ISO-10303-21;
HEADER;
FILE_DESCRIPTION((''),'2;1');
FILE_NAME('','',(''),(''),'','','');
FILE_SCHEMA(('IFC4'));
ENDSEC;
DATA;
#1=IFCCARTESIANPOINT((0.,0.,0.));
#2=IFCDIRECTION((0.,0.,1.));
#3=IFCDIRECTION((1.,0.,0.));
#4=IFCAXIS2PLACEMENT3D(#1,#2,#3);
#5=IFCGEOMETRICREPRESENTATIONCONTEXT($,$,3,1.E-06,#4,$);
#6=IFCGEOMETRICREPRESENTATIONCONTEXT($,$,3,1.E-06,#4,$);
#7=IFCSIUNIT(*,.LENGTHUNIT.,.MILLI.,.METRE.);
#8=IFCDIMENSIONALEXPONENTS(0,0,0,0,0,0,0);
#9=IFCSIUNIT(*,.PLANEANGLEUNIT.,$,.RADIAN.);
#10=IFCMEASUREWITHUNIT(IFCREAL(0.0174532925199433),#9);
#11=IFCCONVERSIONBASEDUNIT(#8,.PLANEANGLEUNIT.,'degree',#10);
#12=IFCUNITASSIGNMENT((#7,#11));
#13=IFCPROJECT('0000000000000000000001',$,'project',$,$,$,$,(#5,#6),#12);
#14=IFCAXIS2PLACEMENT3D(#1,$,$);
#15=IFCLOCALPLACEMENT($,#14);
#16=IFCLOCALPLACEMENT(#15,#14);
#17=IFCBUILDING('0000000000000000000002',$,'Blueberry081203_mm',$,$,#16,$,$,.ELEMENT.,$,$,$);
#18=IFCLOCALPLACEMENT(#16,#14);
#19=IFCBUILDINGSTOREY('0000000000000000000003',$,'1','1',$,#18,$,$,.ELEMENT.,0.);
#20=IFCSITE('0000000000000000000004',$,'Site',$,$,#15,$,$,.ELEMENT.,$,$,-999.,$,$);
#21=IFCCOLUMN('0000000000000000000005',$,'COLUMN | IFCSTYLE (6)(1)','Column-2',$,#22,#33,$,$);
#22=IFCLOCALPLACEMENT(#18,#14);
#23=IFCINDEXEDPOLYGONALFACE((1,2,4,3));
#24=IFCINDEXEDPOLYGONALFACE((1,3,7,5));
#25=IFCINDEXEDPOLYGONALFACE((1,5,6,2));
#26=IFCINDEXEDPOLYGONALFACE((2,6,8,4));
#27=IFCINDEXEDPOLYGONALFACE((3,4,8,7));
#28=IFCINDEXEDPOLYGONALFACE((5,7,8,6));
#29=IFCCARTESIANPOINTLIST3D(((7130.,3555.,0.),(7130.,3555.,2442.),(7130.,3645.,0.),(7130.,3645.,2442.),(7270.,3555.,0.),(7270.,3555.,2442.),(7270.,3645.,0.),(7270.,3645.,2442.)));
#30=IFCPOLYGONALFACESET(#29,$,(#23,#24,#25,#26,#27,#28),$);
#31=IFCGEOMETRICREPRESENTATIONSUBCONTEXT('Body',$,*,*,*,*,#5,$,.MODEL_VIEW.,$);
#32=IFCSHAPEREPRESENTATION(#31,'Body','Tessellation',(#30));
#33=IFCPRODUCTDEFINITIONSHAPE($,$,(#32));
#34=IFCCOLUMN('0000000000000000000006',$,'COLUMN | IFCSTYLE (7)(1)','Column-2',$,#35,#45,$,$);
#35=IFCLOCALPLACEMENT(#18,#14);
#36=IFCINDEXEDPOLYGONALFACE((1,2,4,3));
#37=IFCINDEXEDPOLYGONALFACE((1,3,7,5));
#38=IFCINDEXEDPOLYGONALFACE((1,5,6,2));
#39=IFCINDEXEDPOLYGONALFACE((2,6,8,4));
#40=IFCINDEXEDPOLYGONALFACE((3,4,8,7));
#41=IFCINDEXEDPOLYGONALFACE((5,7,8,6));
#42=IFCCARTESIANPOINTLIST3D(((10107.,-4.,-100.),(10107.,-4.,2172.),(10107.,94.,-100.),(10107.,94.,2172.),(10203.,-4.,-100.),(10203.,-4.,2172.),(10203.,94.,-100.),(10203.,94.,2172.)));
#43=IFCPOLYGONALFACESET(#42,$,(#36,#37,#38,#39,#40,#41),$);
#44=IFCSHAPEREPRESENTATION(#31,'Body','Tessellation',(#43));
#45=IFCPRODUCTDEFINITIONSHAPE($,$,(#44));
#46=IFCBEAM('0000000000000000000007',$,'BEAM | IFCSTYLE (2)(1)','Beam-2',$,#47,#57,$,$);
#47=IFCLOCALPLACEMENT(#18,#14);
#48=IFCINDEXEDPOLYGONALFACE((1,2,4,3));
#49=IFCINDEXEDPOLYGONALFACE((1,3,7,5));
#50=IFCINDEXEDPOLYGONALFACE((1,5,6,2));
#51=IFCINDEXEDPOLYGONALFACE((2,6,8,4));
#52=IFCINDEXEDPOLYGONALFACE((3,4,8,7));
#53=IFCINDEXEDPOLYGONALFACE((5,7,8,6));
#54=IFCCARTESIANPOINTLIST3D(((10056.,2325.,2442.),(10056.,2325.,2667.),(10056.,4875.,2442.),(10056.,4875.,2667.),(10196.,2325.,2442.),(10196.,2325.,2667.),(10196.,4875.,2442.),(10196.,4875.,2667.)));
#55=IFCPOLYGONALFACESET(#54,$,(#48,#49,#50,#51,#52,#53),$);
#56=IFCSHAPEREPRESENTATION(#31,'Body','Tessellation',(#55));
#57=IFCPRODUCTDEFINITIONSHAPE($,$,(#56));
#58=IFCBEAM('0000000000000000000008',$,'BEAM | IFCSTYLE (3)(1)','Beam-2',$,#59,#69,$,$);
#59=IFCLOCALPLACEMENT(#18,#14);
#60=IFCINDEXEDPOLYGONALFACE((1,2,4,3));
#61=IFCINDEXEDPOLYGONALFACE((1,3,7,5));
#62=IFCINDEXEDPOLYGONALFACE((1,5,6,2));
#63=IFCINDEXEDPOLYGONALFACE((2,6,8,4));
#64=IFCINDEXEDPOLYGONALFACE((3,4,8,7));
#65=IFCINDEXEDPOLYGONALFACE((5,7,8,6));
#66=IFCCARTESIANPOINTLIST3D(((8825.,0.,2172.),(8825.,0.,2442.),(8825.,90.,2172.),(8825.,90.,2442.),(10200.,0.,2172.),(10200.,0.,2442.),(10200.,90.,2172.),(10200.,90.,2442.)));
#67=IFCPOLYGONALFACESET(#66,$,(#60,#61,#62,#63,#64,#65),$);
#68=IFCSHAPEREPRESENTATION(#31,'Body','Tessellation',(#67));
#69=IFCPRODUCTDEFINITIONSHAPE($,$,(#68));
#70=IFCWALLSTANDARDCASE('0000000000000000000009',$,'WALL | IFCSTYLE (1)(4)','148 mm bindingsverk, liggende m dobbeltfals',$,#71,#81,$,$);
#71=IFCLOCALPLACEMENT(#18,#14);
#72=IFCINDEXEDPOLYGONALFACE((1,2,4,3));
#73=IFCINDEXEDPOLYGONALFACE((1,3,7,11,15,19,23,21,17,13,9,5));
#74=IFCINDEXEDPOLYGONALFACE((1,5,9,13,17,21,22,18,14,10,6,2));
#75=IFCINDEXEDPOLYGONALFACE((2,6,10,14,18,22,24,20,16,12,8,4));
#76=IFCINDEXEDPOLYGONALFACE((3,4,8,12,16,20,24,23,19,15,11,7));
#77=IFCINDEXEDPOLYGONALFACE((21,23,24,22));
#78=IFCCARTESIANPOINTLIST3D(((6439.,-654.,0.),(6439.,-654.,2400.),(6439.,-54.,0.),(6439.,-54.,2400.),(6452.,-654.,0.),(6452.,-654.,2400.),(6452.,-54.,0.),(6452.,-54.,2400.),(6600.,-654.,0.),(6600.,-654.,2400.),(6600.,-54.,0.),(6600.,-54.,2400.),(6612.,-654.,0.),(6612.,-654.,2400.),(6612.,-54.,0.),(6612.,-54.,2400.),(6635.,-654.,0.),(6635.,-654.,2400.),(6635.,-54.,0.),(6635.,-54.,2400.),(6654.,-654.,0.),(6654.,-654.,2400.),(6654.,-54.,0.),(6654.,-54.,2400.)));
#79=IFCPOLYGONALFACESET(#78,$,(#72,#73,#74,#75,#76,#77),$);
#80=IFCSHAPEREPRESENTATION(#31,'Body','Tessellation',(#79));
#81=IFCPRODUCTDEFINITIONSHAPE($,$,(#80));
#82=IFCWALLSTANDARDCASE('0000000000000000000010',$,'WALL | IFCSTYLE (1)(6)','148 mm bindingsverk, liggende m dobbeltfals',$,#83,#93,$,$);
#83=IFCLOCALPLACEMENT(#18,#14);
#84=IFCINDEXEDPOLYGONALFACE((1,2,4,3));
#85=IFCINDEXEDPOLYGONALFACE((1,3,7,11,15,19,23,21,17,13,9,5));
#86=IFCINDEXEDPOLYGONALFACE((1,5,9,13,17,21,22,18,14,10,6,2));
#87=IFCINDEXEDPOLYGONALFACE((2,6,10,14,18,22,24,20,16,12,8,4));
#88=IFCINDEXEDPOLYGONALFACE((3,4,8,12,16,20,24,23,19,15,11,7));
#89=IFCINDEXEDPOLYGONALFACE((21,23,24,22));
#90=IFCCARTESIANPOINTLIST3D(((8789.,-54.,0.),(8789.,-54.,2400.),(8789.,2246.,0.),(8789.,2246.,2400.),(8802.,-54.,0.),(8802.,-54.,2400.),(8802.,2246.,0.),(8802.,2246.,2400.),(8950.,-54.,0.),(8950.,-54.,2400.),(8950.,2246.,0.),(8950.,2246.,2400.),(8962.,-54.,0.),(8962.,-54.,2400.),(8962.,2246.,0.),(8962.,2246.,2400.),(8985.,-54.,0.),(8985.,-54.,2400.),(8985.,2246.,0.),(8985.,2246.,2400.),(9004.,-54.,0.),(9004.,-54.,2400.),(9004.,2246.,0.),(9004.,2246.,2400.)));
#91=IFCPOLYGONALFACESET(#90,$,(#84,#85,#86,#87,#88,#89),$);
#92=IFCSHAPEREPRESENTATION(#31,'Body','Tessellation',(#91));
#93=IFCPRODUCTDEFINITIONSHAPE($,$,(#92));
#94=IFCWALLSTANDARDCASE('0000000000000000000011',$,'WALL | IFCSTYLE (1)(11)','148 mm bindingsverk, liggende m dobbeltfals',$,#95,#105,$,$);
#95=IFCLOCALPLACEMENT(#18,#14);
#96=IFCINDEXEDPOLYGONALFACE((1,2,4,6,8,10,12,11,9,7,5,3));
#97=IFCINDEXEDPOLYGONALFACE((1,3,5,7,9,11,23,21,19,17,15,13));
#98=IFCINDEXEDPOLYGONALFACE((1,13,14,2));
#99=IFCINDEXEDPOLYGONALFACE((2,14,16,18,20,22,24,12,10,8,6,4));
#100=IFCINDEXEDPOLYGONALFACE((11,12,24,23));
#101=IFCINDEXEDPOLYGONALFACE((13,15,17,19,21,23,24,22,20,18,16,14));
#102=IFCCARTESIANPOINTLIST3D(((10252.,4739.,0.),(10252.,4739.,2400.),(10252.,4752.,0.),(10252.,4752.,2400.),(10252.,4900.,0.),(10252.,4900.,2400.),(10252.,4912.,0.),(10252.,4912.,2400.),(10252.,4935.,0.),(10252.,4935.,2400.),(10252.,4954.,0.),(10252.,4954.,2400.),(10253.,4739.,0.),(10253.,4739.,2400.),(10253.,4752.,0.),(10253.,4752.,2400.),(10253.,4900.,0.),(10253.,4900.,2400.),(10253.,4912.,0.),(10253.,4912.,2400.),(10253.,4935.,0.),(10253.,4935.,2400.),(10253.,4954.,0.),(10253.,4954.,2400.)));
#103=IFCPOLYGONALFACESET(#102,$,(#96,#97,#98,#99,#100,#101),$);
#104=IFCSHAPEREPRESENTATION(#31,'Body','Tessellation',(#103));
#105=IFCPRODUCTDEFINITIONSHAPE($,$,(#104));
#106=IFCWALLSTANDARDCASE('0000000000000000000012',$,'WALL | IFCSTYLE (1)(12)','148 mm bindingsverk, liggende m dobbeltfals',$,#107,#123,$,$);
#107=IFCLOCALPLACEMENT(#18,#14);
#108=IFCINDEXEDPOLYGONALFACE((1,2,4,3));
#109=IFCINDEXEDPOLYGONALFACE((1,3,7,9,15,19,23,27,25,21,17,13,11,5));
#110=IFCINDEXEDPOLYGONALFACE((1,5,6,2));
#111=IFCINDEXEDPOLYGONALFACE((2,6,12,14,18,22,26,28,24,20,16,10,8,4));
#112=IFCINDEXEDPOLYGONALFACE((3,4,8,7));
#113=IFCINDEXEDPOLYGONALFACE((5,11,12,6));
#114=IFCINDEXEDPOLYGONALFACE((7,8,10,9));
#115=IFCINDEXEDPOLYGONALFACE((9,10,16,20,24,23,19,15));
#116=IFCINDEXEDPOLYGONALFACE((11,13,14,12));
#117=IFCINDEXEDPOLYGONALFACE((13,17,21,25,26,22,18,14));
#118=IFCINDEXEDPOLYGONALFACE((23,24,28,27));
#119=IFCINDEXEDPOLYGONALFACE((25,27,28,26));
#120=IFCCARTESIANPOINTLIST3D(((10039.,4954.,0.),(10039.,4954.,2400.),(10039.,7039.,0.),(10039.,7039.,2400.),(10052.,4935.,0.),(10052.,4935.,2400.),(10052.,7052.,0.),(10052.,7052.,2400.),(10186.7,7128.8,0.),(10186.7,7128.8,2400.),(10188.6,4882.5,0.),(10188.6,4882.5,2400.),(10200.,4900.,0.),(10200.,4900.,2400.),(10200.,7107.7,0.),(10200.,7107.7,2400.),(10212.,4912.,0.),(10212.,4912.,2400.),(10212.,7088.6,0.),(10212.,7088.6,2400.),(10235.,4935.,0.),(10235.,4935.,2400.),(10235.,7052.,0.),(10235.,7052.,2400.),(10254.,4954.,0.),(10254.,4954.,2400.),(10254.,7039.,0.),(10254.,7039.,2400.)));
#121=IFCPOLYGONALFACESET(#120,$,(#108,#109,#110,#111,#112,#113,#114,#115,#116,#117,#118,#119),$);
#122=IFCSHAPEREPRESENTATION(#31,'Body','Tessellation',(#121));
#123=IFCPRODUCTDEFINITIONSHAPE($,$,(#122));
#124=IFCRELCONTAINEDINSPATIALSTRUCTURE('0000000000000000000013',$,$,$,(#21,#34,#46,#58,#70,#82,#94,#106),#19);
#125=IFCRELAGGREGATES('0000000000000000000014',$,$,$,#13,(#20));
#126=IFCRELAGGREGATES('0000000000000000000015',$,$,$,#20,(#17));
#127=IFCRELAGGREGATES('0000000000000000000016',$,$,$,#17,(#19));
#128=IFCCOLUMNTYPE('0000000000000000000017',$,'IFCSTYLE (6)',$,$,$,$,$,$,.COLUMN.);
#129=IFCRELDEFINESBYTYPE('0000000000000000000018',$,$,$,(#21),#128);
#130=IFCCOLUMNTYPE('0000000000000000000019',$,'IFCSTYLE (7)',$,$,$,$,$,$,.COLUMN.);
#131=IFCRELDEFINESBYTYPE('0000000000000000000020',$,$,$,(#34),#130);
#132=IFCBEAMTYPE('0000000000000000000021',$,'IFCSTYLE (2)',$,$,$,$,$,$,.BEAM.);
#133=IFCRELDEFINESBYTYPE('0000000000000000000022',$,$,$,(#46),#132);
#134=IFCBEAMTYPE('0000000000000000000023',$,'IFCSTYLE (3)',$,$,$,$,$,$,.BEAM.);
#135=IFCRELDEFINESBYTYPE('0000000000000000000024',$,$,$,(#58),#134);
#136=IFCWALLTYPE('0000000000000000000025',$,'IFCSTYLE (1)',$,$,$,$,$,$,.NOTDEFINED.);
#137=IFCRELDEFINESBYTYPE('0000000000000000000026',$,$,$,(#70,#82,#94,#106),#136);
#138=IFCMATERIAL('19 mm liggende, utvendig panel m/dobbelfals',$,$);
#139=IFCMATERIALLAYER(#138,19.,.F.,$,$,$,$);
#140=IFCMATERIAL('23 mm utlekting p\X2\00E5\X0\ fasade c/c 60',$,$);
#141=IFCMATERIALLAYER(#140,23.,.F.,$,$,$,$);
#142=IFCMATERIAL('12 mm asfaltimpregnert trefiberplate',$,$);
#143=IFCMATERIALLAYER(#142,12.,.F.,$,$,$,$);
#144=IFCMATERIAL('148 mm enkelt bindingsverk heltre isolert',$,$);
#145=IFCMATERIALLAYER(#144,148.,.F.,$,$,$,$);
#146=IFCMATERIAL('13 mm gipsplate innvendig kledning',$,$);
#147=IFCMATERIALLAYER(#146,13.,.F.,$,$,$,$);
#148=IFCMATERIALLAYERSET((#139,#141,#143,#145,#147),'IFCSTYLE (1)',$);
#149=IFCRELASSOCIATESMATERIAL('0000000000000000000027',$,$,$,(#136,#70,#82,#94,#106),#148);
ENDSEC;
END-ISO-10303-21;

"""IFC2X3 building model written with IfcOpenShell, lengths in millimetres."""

from ifc_helpers import new_model, entity, si_unit, converted_unit, frame, frame_2d, origin, origin_with_axes, place, context, subcontext, project, spatial, polyline, segment, composite_curve, rectangle, outline, extrude, source, transform, mapped, material, layer, layer_set, layer_usage, type_object, element, save


model = new_model("IFC2X3")

# Units and contexts
context_of_model_1 = context(None, 3, precision=1e-06, world=origin_with_axes())
context_of_model_2 = context(None, 3, precision=1e-06, world=origin_with_axes())
body_context = subcontext(context_of_model_1, "Body", None, "MODEL_VIEW")
ifc_project = project(units=[si_unit("LENGTHUNIT", "METRE", prefix="MILLI"), converted_unit("PLANEANGLEUNIT", "degree", entity("IfcReal", 0.0174532925199433), si_unit("PLANEANGLEUNIT", "RADIAN"), dimensions=[0, 0, 0, 0, 0, 0, 0])], contexts=[context_of_model_1, context_of_model_2])

# Site, building, storey
site_placement = place(None, origin())
site = spatial("IfcSite", under=ifc_project, at=site_placement, Name="Site", CompositionType="ELEMENT", RefElevation=-999.0)
building_placement = place(site_placement, origin())
building = spatial("IfcBuilding", under=site, at=building_placement, Name="Blueberry081203_mm", CompositionType="ELEMENT")
storey_placement = place(building_placement, origin())
storey = spatial("IfcBuildingStorey", under=building, at=storey_placement, Name="1", Description="1", CompositionType="ELEMENT", Elevation=0.0)

# Columns
column_type_1 = type_object("IfcColumnType", Name="IFCSTYLE (6)", PredefinedType="COLUMN")
shared_shape_1 = source(origin(), body_context, "Body", "SweptSolid", [
    extrude(rectangle(XDim=140.0, YDim=90.0, at=frame_2d((70.0, 45.0), x_axis=(1.0, 0.0))), frame((0.0, 0.0, 0.0), z_axis=(1.0, 0.0, 0.0), x_axis=(0.0, 1.0, 0.0)), (0.0, 0.0, 1.0), 1.0),
])
column_1_placement = place(storey_placement, frame((7130.0, 3555.0, 0.0), z_axis=(0.0, 1.0, 0.0), x_axis=(0.0, 0.0, 1.0)))
element("IfcColumn", 1, at=column_1_placement, inside=storey, type_object=column_type_1, Name="COLUMN | IFCSTYLE (6)(1)", Description="Column-2", context=body_context, shape_type="MappedRepresentation", held_by="IfcProductRepresentation", body=[
    mapped(shared_shape_1, transform((0.0, 0.0, 0.0), x_axis=(1.0, 0.0, 0.0), y_axis=(0.0, 1.0, 0.0), z_axis=(0.0, 0.0, 1.0), scale=2441.999912, scale2=1.0, scale3=1.0, uniform=False)),
])
column_type_2 = type_object("IfcColumnType", Name="IFCSTYLE (7)", PredefinedType="COLUMN")
shared_shape_2 = source(origin(), body_context, "Body", "SweptSolid", [
    extrude(rectangle(XDim=96.0, YDim=98.0, at=frame_2d((48.0, 49.0), x_axis=(1.0, 0.0))), frame((0.0, 0.0, 0.0), z_axis=(1.0, 0.0, 0.0), x_axis=(0.0, 1.0, 0.0)), (0.0, 0.0, 1.0), 1.0),
])
column_2_placement = place(storey_placement, frame((10107.0, -4.0, -100.0), z_axis=(0.0, 1.0, 0.0), x_axis=(0.0, 0.0, 1.0)))
element("IfcColumn", 2, at=column_2_placement, inside=storey, type_object=column_type_2, Name="COLUMN | IFCSTYLE (7)(1)", Description="Column-2", context=body_context, shape_type="MappedRepresentation", held_by="IfcProductRepresentation", body=[
    mapped(shared_shape_2, transform((0.0, 0.0, 0.0), x_axis=(1.0, 0.0, 0.0), y_axis=(0.0, 1.0, 0.0), z_axis=(0.0, 0.0, 1.0), scale=2272.000074, scale2=1.0, scale3=1.0, uniform=False)),
])

# Beams
beam_type_1 = type_object("IfcBeamType", Name="IFCSTYLE (2)", PredefinedType="BEAM")
shared_shape_3 = source(origin(), body_context, "Body", "SweptSolid", [
    extrude(rectangle(XDim=140.0, YDim=225.0, at=frame_2d((70.0, 112.5), x_axis=(1.0, 0.0))), frame((0.0, 0.0, 0.0), z_axis=(1.0, 0.0, 0.0), x_axis=(0.0, 1.0, 0.0)), (0.0, 0.0, 1.0), 1.0),
])
beam_1_placement = place(storey_placement, frame((10056.0, 4875.0, 2442.0), z_axis=(0.0, 0.0, 1.0), x_axis=(0.0, -1.0, 0.0)))
element("IfcBeam", 3, at=beam_1_placement, inside=storey, type_object=beam_type_1, Name="BEAM | IFCSTYLE (2)(1)", Description="Beam-2", context=body_context, shape_type="MappedRepresentation", held_by="IfcProductRepresentation", body=[
    mapped(shared_shape_3, transform((0.0, 0.0, 0.0), x_axis=(1.0, 0.0, 0.0), y_axis=(0.0, 1.0, 0.0), z_axis=(0.0, 0.0, 1.0), scale=2549.999952, scale2=1.0, scale3=1.0, uniform=False)),
])
beam_type_2 = type_object("IfcBeamType", Name="IFCSTYLE (3)", PredefinedType="BEAM")
shared_shape_4 = source(origin(), body_context, "Body", "SweptSolid", [
    extrude(rectangle(XDim=90.0, YDim=270.0, at=frame_2d((45.0, 135.0), x_axis=(1.0, 0.0))), frame((0.0, 0.0, 0.0), z_axis=(1.0, 0.0, 0.0), x_axis=(0.0, 1.0, 0.0)), (0.0, 0.0, 1.0), 1.0),
])
beam_2_placement = place(storey_placement, frame((8825.0, 0.0, 2172.0)))
element("IfcBeam", 4, at=beam_2_placement, inside=storey, type_object=beam_type_2, Name="BEAM | IFCSTYLE (3)(1)", Description="Beam-2", context=body_context, shape_type="MappedRepresentation", held_by="IfcProductRepresentation", body=[
    mapped(shared_shape_4, transform((0.0, 0.0, 0.0), x_axis=(1.0, 0.0, 0.0), y_axis=(0.0, 1.0, 0.0), z_axis=(0.0, 0.0, 1.0), scale=1374.999046, scale2=1.0, scale3=1.0, uniform=False)),
])

# Wall
ifc_material_1 = material(Name="19 mm liggende, utvendig panel m/dobbelfals")
ifc_layer_1 = layer(ifc_material_1, 19.0, ventilated=False)
ifc_material_2 = material(Name="23 mm utlekting på fasade c/c 60")
ifc_layer_2 = layer(ifc_material_2, 23.0, ventilated=False)
ifc_material_3 = material(Name="12 mm asfaltimpregnert trefiberplate")
ifc_layer_3 = layer(ifc_material_3, 12.0, ventilated=False)
ifc_material_4 = material(Name="148 mm enkelt bindingsverk heltre isolert")
ifc_layer_4 = layer(ifc_material_4, 148.0, ventilated=False)
ifc_material_5 = material(Name="13 mm gipsplate innvendig kledning")
ifc_layer_5 = layer(ifc_material_5, 13.0, ventilated=False)
ifc_layer_set_1 = layer_set([ifc_layer_1, ifc_layer_2, ifc_layer_3, ifc_layer_4, ifc_layer_5], Name="IFCSTYLE (1)")
ifc_layer_usage_1 = layer_usage(ifc_layer_set_1, "AXIS2", "POSITIVE", 0.0)
wall_type_1 = type_object("IfcWallType", Name="IFCSTYLE (1)", PredefinedType="NOTDEFINED", material=ifc_layer_set_1)
wall_1_placement = place(storey_placement, frame((6654.0, -654.0, 0.0), z_axis=(0.0, 0.0, 1.0), x_axis=(0.0, 1.0, 0.0)))
element("IfcWallStandardCase", 5, at=wall_1_placement, inside=storey, type_object=wall_type_1, material=ifc_layer_usage_1, Name="WALL | IFCSTYLE (1)(4)", Description="148 mm bindingsverk, liggende m dobbeltfals", context=body_context, shape_type="SweptSolid", held_by="IfcProductRepresentation", body=[
    extrude(outline(composite_curve([segment(polyline([(0.0, 19.0), (0.0, 0.0)]), True, "CONTINUOUS"), segment(polyline([(0.0, 0.0), (600.0, 0.0)]), True, "CONTINUOUS"), segment(polyline([(600.0, 0.0), (600.0, 19.0)]), True, "CONTINUOUS"), segment(polyline([(600.0, 19.0), (600.0, 42.0)]), True, "CONTINUOUS"), segment(polyline([(600.0, 42.0), (600.0, 54.0)]), True, "CONTINUOUS"), segment(polyline([(600.0, 54.0), (600.0, 202.0)]), True, "CONTINUOUS"), segment(polyline([(600.0, 202.0), (600.0, 215.0)]), True, "CONTINUOUS"), segment(polyline([(600.0, 215.0), (0.0, 215.0)]), True, "CONTINUOUS"), segment(polyline([(0.0, 215.0), (0.0, 202.0)]), True, "CONTINUOUS"), segment(polyline([(0.0, 202.0), (0.0, 54.0)]), True, "CONTINUOUS"), segment(polyline([(0.0, 54.0), (0.0, 42.0)]), True, "CONTINUOUS"), segment(polyline([(0.0, 42.0), (0.0, 19.0)]), True, "CONTINUOUS")], self_intersect=False)), origin(), (0.0, 0.0, 1.0), 2400.0),
])

# Wall
ifc_layer_usage_2 = layer_usage(ifc_layer_set_1, "AXIS2", "POSITIVE", 0.0)
wall_2_placement = place(storey_placement, frame((9004.0, -54.0, 0.0), z_axis=(0.0, 0.0, 1.0), x_axis=(0.0, 1.0, 0.0)))
element("IfcWallStandardCase", 6, at=wall_2_placement, inside=storey, type_object=wall_type_1, material=ifc_layer_usage_2, Name="WALL | IFCSTYLE (1)(6)", Description="148 mm bindingsverk, liggende m dobbeltfals", context=body_context, shape_type="SweptSolid", held_by="IfcProductRepresentation", body=[
    extrude(outline(composite_curve([segment(polyline([(0.0, 19.0), (0.0, 0.0)]), True, "CONTINUOUS"), segment(polyline([(0.0, 0.0), (2300.0, 0.0)]), True, "CONTINUOUS"), segment(polyline([(2300.0, 0.0), (2300.0, 19.0)]), True, "CONTINUOUS"), segment(polyline([(2300.0, 19.0), (2300.0, 42.0)]), True, "CONTINUOUS"), segment(polyline([(2300.0, 42.0), (2300.0, 54.0)]), True, "CONTINUOUS"), segment(polyline([(2300.0, 54.0), (2300.0, 202.0)]), True, "CONTINUOUS"), segment(polyline([(2300.0, 202.0), (2300.0, 215.0)]), True, "CONTINUOUS"), segment(polyline([(2300.0, 215.0), (0.0, 215.0)]), True, "CONTINUOUS"), segment(polyline([(0.0, 215.0), (0.0, 202.0)]), True, "CONTINUOUS"), segment(polyline([(0.0, 202.0), (0.0, 54.0)]), True, "CONTINUOUS"), segment(polyline([(0.0, 54.0), (0.0, 42.0)]), True, "CONTINUOUS"), segment(polyline([(0.0, 42.0), (0.0, 19.0)]), True, "CONTINUOUS")], self_intersect=False)), origin(), (0.0, 0.0, 1.0), 2400.0),
])

# Walls
ifc_layer_usage_3 = layer_usage(ifc_layer_set_1, "AXIS2", "POSITIVE", 0.0)
wall_3_placement = place(storey_placement, frame((10253.0, 4954.0, 0.0), z_axis=(0.0, 0.0, 1.0), x_axis=(-1.0, 0.0, 0.0)))
element("IfcWallStandardCase", 7, at=wall_3_placement, inside=storey, type_object=wall_type_1, material=ifc_layer_usage_3, Name="WALL | IFCSTYLE (1)(11)", Description="148 mm bindingsverk, liggende m dobbeltfals", context=body_context, shape_type="SweptSolid", held_by="IfcProductRepresentation", body=[
    extrude(outline(composite_curve([segment(polyline([(0.0, 19.0), (0.0, 0.0)]), True, "CONTINUOUS"), segment(polyline([(0.0, 0.0), (1.0, 0.0)]), True, "CONTINUOUS"), segment(polyline([(1.0, 0.0), (1.0, 19.0)]), True, "CONTINUOUS"), segment(polyline([(1.0, 19.0), (1.0, 42.0)]), True, "CONTINUOUS"), segment(polyline([(1.0, 42.0), (1.0, 54.0)]), True, "CONTINUOUS"), segment(polyline([(1.0, 54.0), (1.0, 202.0)]), True, "CONTINUOUS"), segment(polyline([(1.0, 202.0), (1.0, 215.0)]), True, "CONTINUOUS"), segment(polyline([(1.0, 215.0), (0.0, 215.0)]), True, "CONTINUOUS"), segment(polyline([(0.0, 215.0), (0.0, 202.0)]), True, "CONTINUOUS"), segment(polyline([(0.0, 202.0), (0.0, 54.0)]), True, "CONTINUOUS"), segment(polyline([(0.0, 54.0), (0.0, 42.0)]), True, "CONTINUOUS"), segment(polyline([(0.0, 42.0), (0.0, 19.0)]), True, "CONTINUOUS")], self_intersect=False)), origin(), (0.0, 0.0, 1.0), 2400.0),
])
ifc_layer_usage_4 = layer_usage(ifc_layer_set_1, "AXIS2", "POSITIVE", 0.0)
wall_4_placement = place(storey_placement, frame((10254.0, 4954.0, 0.0), z_axis=(0.0, 0.0, 1.0), x_axis=(0.0, 1.0, 0.0)))
element("IfcWallStandardCase", 8, at=wall_4_placement, inside=storey, type_object=wall_type_1, material=ifc_layer_usage_4, Name="WALL | IFCSTYLE (1)(12)", Description="148 mm bindingsverk, liggende m dobbeltfals", context=body_context, shape_type="SweptSolid", held_by="IfcProductRepresentation", body=[
    extrude(outline(composite_curve([segment(polyline([(-19.0, 19.0), (0.0, 0.0)]), True, "CONTINUOUS"), segment(polyline([(0.0, 0.0), (2085.0, 0.0)]), True, "CONTINUOUS"), segment(polyline([(2085.0, 0.0), (2098.0, 19.0)]), True, "CONTINUOUS"), segment(polyline([(2098.0, 19.0), (2134.6, 42.0)]), True, "CONTINUOUS"), segment(polyline([(2134.6, 42.0), (2153.7, 54.0)]), True, "CONTINUOUS"), segment(polyline([(2153.7, 54.0), (2174.8, 67.2)]), True, "CONTINUOUS"), segment(polyline([(2174.8, 67.2), (2098.0, 202.0)]), True, "CONTINUOUS"), segment(polyline([(2098.0, 202.0), (2085.0, 215.0)]), True, "CONTINUOUS"), segment(polyline([(2085.0, 215.0), (0.0, 215.0)]), True, "CONTINUOUS"), segment(polyline([(0.0, 215.0), (-19.0, 202.0)]), True, "CONTINUOUS"), segment(polyline([(-19.0, 202.0), (-71.5, 65.4)]), True, "CONTINUOUS"), segment(polyline([(-71.5, 65.4), (-54.0, 54.0)]), True, "CONTINUOUS"), segment(polyline([(-54.0, 54.0), (-42.0, 42.0)]), True, "CONTINUOUS"), segment(polyline([(-42.0, 42.0), (-19.0, 19.0)]), True, "CONTINUOUS")], self_intersect=False)), origin(), (0.0, 0.0, 1.0), 2400.0),
])

save(model, "model.ifc")
